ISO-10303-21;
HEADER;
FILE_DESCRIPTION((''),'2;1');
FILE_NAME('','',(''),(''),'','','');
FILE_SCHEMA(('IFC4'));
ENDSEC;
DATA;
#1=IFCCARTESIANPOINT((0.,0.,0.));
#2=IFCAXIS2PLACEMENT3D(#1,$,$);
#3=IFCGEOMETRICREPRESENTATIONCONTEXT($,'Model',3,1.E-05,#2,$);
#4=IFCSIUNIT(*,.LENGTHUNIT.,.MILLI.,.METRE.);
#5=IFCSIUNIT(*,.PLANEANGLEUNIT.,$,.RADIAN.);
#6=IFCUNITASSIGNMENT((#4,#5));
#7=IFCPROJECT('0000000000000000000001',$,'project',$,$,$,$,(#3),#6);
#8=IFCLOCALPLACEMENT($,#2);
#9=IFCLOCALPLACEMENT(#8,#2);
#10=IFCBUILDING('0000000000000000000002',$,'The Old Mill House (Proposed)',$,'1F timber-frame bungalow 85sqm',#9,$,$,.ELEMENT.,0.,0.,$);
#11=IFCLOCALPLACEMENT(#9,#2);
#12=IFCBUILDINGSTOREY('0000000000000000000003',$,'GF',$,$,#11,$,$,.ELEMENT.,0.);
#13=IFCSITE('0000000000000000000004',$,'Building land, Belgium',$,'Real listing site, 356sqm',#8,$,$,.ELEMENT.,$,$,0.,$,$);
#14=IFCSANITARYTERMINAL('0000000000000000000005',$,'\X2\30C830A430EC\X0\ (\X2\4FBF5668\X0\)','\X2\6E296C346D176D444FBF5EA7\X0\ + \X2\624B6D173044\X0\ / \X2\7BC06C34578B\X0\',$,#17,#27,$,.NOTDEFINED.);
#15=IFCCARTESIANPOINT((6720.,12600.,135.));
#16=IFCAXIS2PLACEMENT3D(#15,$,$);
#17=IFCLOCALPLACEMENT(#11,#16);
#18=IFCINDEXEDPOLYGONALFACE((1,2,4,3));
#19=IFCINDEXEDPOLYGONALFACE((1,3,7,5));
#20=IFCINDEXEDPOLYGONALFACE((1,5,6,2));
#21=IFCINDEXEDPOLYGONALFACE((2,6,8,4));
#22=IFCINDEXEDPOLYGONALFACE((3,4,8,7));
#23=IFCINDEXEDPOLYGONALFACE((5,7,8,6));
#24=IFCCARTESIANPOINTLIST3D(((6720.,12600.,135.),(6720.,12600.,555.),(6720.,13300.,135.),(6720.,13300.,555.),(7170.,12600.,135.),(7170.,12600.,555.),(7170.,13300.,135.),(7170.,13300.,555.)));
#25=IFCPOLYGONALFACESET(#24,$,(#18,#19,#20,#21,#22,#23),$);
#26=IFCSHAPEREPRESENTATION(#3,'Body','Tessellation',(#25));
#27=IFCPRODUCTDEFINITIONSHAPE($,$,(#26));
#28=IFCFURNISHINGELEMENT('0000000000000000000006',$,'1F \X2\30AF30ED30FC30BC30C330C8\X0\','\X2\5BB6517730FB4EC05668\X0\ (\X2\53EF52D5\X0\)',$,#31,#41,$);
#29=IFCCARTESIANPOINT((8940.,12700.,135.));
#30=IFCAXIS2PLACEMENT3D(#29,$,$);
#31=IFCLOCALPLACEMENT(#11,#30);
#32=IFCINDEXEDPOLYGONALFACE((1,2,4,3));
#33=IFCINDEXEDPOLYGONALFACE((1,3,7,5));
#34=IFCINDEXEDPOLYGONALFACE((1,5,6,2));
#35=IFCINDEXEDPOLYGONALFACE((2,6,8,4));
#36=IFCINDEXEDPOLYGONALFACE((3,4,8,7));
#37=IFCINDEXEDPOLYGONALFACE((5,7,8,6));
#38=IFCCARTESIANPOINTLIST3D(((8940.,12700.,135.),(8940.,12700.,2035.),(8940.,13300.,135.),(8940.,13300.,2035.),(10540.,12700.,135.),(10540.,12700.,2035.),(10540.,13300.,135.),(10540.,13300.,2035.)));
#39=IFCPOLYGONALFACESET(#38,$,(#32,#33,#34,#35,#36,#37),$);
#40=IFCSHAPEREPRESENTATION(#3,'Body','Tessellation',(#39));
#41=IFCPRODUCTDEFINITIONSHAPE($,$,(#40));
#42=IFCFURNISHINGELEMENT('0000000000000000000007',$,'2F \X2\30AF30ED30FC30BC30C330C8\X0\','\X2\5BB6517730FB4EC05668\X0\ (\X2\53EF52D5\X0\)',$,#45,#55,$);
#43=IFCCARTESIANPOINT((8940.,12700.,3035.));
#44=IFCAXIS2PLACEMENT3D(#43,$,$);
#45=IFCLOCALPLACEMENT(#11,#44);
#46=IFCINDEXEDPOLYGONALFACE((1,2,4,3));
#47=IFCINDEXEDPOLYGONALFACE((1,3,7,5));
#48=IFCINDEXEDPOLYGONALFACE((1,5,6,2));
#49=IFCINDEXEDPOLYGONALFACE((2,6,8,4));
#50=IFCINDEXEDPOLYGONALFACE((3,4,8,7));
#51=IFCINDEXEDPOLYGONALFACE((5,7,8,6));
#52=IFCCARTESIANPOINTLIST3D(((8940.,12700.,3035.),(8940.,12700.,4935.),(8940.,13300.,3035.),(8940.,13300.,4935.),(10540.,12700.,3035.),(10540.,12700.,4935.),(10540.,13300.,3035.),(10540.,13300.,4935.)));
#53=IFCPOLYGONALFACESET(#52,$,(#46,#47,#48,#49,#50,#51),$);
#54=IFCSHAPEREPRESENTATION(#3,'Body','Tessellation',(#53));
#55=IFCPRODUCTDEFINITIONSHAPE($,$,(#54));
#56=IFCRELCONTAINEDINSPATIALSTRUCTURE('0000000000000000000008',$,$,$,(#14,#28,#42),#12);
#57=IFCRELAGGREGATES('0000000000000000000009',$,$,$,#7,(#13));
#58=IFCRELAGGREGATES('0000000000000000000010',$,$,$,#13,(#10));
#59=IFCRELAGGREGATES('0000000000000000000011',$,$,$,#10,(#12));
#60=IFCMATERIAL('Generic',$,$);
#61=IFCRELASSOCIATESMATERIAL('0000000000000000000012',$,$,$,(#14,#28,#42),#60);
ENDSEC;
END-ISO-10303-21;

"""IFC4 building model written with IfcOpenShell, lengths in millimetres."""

from ifc_helpers import new_model, si_unit, frame, frame_2d, origin, place, context, project, spatial, rectangle, extrude, material, element, save


model = new_model("IFC4")

# Units and contexts
model_context = context("Model", 3, precision=1e-05, world=origin())
ifc_project = project(units=[si_unit("LENGTHUNIT", "METRE", prefix="MILLI"), si_unit("PLANEANGLEUNIT", "RADIAN")], contexts=[model_context])

# Site, building, storey
site_placement = place(None, origin())
site = spatial("IfcSite", under=ifc_project, at=site_placement, Name="Building land, Belgium", ObjectType="Real listing site, 356sqm", CompositionType="ELEMENT", RefElevation=0.0)
building_placement = place(site_placement, origin())
building = spatial("IfcBuilding", under=site, at=building_placement, Name="The Old Mill House (Proposed)", ObjectType="1F timber-frame bungalow 85sqm", CompositionType="ELEMENT", ElevationOfRefHeight=0.0, ElevationOfTerrain=0.0)
storey_placement = place(building_placement, origin())
storey = spatial("IfcBuildingStorey", under=building, at=storey_placement, Name="GF", CompositionType="ELEMENT", Elevation=0.0)

# Sanitary terminal
ifc_material_1 = material(Name="Generic")
sanitary_terminal_1_placement = place(storey_placement, frame((6720.0, 12600.0, 135.0)))
element("IfcSanitaryTerminal", 1, at=sanitary_terminal_1_placement, inside=storey, material=ifc_material_1, Name="トイレ (便器)", Description="温水洗浄便座 + 手洗い / 節水型", PredefinedType="NOTDEFINED", context=model_context, shape_type="SweptSolid", body=[
    extrude(rectangle(XDim=450.0, YDim=700.0, at=frame_2d((225.0, 350.0))), frame((6720.0, 12600.0, 135.0)), (0.0, 0.0, 1.0), 420.0),
])

# Furnishing elements
furnishing_1_placement = place(storey_placement, frame((8940.0, 12700.0, 135.0)))
element("IfcFurnishingElement", 2, at=furnishing_1_placement, inside=storey, material=ifc_material_1, Name="1F クローゼット", Description="家具・什器 (可動)", context=model_context, shape_type="SweptSolid", body=[
    extrude(rectangle(XDim=1600.0, YDim=600.0, at=frame_2d((800.0, 300.0))), frame((8940.0, 12700.0, 135.0)), (0.0, 0.0, 1.0), 1900.0),
])
furnishing_2_placement = place(storey_placement, frame((8940.0, 12700.0, 3035.0)))
element("IfcFurnishingElement", 3, at=furnishing_2_placement, inside=storey, material=ifc_material_1, Name="2F クローゼット", Description="家具・什器 (可動)", context=model_context, shape_type="SweptSolid", body=[
    extrude(rectangle(XDim=1600.0, YDim=600.0, at=frame_2d((800.0, 300.0))), frame((8940.0, 12700.0, 3035.0)), (0.0, 0.0, 1.0), 1900.0),
])

save(model, "model.ifc")
